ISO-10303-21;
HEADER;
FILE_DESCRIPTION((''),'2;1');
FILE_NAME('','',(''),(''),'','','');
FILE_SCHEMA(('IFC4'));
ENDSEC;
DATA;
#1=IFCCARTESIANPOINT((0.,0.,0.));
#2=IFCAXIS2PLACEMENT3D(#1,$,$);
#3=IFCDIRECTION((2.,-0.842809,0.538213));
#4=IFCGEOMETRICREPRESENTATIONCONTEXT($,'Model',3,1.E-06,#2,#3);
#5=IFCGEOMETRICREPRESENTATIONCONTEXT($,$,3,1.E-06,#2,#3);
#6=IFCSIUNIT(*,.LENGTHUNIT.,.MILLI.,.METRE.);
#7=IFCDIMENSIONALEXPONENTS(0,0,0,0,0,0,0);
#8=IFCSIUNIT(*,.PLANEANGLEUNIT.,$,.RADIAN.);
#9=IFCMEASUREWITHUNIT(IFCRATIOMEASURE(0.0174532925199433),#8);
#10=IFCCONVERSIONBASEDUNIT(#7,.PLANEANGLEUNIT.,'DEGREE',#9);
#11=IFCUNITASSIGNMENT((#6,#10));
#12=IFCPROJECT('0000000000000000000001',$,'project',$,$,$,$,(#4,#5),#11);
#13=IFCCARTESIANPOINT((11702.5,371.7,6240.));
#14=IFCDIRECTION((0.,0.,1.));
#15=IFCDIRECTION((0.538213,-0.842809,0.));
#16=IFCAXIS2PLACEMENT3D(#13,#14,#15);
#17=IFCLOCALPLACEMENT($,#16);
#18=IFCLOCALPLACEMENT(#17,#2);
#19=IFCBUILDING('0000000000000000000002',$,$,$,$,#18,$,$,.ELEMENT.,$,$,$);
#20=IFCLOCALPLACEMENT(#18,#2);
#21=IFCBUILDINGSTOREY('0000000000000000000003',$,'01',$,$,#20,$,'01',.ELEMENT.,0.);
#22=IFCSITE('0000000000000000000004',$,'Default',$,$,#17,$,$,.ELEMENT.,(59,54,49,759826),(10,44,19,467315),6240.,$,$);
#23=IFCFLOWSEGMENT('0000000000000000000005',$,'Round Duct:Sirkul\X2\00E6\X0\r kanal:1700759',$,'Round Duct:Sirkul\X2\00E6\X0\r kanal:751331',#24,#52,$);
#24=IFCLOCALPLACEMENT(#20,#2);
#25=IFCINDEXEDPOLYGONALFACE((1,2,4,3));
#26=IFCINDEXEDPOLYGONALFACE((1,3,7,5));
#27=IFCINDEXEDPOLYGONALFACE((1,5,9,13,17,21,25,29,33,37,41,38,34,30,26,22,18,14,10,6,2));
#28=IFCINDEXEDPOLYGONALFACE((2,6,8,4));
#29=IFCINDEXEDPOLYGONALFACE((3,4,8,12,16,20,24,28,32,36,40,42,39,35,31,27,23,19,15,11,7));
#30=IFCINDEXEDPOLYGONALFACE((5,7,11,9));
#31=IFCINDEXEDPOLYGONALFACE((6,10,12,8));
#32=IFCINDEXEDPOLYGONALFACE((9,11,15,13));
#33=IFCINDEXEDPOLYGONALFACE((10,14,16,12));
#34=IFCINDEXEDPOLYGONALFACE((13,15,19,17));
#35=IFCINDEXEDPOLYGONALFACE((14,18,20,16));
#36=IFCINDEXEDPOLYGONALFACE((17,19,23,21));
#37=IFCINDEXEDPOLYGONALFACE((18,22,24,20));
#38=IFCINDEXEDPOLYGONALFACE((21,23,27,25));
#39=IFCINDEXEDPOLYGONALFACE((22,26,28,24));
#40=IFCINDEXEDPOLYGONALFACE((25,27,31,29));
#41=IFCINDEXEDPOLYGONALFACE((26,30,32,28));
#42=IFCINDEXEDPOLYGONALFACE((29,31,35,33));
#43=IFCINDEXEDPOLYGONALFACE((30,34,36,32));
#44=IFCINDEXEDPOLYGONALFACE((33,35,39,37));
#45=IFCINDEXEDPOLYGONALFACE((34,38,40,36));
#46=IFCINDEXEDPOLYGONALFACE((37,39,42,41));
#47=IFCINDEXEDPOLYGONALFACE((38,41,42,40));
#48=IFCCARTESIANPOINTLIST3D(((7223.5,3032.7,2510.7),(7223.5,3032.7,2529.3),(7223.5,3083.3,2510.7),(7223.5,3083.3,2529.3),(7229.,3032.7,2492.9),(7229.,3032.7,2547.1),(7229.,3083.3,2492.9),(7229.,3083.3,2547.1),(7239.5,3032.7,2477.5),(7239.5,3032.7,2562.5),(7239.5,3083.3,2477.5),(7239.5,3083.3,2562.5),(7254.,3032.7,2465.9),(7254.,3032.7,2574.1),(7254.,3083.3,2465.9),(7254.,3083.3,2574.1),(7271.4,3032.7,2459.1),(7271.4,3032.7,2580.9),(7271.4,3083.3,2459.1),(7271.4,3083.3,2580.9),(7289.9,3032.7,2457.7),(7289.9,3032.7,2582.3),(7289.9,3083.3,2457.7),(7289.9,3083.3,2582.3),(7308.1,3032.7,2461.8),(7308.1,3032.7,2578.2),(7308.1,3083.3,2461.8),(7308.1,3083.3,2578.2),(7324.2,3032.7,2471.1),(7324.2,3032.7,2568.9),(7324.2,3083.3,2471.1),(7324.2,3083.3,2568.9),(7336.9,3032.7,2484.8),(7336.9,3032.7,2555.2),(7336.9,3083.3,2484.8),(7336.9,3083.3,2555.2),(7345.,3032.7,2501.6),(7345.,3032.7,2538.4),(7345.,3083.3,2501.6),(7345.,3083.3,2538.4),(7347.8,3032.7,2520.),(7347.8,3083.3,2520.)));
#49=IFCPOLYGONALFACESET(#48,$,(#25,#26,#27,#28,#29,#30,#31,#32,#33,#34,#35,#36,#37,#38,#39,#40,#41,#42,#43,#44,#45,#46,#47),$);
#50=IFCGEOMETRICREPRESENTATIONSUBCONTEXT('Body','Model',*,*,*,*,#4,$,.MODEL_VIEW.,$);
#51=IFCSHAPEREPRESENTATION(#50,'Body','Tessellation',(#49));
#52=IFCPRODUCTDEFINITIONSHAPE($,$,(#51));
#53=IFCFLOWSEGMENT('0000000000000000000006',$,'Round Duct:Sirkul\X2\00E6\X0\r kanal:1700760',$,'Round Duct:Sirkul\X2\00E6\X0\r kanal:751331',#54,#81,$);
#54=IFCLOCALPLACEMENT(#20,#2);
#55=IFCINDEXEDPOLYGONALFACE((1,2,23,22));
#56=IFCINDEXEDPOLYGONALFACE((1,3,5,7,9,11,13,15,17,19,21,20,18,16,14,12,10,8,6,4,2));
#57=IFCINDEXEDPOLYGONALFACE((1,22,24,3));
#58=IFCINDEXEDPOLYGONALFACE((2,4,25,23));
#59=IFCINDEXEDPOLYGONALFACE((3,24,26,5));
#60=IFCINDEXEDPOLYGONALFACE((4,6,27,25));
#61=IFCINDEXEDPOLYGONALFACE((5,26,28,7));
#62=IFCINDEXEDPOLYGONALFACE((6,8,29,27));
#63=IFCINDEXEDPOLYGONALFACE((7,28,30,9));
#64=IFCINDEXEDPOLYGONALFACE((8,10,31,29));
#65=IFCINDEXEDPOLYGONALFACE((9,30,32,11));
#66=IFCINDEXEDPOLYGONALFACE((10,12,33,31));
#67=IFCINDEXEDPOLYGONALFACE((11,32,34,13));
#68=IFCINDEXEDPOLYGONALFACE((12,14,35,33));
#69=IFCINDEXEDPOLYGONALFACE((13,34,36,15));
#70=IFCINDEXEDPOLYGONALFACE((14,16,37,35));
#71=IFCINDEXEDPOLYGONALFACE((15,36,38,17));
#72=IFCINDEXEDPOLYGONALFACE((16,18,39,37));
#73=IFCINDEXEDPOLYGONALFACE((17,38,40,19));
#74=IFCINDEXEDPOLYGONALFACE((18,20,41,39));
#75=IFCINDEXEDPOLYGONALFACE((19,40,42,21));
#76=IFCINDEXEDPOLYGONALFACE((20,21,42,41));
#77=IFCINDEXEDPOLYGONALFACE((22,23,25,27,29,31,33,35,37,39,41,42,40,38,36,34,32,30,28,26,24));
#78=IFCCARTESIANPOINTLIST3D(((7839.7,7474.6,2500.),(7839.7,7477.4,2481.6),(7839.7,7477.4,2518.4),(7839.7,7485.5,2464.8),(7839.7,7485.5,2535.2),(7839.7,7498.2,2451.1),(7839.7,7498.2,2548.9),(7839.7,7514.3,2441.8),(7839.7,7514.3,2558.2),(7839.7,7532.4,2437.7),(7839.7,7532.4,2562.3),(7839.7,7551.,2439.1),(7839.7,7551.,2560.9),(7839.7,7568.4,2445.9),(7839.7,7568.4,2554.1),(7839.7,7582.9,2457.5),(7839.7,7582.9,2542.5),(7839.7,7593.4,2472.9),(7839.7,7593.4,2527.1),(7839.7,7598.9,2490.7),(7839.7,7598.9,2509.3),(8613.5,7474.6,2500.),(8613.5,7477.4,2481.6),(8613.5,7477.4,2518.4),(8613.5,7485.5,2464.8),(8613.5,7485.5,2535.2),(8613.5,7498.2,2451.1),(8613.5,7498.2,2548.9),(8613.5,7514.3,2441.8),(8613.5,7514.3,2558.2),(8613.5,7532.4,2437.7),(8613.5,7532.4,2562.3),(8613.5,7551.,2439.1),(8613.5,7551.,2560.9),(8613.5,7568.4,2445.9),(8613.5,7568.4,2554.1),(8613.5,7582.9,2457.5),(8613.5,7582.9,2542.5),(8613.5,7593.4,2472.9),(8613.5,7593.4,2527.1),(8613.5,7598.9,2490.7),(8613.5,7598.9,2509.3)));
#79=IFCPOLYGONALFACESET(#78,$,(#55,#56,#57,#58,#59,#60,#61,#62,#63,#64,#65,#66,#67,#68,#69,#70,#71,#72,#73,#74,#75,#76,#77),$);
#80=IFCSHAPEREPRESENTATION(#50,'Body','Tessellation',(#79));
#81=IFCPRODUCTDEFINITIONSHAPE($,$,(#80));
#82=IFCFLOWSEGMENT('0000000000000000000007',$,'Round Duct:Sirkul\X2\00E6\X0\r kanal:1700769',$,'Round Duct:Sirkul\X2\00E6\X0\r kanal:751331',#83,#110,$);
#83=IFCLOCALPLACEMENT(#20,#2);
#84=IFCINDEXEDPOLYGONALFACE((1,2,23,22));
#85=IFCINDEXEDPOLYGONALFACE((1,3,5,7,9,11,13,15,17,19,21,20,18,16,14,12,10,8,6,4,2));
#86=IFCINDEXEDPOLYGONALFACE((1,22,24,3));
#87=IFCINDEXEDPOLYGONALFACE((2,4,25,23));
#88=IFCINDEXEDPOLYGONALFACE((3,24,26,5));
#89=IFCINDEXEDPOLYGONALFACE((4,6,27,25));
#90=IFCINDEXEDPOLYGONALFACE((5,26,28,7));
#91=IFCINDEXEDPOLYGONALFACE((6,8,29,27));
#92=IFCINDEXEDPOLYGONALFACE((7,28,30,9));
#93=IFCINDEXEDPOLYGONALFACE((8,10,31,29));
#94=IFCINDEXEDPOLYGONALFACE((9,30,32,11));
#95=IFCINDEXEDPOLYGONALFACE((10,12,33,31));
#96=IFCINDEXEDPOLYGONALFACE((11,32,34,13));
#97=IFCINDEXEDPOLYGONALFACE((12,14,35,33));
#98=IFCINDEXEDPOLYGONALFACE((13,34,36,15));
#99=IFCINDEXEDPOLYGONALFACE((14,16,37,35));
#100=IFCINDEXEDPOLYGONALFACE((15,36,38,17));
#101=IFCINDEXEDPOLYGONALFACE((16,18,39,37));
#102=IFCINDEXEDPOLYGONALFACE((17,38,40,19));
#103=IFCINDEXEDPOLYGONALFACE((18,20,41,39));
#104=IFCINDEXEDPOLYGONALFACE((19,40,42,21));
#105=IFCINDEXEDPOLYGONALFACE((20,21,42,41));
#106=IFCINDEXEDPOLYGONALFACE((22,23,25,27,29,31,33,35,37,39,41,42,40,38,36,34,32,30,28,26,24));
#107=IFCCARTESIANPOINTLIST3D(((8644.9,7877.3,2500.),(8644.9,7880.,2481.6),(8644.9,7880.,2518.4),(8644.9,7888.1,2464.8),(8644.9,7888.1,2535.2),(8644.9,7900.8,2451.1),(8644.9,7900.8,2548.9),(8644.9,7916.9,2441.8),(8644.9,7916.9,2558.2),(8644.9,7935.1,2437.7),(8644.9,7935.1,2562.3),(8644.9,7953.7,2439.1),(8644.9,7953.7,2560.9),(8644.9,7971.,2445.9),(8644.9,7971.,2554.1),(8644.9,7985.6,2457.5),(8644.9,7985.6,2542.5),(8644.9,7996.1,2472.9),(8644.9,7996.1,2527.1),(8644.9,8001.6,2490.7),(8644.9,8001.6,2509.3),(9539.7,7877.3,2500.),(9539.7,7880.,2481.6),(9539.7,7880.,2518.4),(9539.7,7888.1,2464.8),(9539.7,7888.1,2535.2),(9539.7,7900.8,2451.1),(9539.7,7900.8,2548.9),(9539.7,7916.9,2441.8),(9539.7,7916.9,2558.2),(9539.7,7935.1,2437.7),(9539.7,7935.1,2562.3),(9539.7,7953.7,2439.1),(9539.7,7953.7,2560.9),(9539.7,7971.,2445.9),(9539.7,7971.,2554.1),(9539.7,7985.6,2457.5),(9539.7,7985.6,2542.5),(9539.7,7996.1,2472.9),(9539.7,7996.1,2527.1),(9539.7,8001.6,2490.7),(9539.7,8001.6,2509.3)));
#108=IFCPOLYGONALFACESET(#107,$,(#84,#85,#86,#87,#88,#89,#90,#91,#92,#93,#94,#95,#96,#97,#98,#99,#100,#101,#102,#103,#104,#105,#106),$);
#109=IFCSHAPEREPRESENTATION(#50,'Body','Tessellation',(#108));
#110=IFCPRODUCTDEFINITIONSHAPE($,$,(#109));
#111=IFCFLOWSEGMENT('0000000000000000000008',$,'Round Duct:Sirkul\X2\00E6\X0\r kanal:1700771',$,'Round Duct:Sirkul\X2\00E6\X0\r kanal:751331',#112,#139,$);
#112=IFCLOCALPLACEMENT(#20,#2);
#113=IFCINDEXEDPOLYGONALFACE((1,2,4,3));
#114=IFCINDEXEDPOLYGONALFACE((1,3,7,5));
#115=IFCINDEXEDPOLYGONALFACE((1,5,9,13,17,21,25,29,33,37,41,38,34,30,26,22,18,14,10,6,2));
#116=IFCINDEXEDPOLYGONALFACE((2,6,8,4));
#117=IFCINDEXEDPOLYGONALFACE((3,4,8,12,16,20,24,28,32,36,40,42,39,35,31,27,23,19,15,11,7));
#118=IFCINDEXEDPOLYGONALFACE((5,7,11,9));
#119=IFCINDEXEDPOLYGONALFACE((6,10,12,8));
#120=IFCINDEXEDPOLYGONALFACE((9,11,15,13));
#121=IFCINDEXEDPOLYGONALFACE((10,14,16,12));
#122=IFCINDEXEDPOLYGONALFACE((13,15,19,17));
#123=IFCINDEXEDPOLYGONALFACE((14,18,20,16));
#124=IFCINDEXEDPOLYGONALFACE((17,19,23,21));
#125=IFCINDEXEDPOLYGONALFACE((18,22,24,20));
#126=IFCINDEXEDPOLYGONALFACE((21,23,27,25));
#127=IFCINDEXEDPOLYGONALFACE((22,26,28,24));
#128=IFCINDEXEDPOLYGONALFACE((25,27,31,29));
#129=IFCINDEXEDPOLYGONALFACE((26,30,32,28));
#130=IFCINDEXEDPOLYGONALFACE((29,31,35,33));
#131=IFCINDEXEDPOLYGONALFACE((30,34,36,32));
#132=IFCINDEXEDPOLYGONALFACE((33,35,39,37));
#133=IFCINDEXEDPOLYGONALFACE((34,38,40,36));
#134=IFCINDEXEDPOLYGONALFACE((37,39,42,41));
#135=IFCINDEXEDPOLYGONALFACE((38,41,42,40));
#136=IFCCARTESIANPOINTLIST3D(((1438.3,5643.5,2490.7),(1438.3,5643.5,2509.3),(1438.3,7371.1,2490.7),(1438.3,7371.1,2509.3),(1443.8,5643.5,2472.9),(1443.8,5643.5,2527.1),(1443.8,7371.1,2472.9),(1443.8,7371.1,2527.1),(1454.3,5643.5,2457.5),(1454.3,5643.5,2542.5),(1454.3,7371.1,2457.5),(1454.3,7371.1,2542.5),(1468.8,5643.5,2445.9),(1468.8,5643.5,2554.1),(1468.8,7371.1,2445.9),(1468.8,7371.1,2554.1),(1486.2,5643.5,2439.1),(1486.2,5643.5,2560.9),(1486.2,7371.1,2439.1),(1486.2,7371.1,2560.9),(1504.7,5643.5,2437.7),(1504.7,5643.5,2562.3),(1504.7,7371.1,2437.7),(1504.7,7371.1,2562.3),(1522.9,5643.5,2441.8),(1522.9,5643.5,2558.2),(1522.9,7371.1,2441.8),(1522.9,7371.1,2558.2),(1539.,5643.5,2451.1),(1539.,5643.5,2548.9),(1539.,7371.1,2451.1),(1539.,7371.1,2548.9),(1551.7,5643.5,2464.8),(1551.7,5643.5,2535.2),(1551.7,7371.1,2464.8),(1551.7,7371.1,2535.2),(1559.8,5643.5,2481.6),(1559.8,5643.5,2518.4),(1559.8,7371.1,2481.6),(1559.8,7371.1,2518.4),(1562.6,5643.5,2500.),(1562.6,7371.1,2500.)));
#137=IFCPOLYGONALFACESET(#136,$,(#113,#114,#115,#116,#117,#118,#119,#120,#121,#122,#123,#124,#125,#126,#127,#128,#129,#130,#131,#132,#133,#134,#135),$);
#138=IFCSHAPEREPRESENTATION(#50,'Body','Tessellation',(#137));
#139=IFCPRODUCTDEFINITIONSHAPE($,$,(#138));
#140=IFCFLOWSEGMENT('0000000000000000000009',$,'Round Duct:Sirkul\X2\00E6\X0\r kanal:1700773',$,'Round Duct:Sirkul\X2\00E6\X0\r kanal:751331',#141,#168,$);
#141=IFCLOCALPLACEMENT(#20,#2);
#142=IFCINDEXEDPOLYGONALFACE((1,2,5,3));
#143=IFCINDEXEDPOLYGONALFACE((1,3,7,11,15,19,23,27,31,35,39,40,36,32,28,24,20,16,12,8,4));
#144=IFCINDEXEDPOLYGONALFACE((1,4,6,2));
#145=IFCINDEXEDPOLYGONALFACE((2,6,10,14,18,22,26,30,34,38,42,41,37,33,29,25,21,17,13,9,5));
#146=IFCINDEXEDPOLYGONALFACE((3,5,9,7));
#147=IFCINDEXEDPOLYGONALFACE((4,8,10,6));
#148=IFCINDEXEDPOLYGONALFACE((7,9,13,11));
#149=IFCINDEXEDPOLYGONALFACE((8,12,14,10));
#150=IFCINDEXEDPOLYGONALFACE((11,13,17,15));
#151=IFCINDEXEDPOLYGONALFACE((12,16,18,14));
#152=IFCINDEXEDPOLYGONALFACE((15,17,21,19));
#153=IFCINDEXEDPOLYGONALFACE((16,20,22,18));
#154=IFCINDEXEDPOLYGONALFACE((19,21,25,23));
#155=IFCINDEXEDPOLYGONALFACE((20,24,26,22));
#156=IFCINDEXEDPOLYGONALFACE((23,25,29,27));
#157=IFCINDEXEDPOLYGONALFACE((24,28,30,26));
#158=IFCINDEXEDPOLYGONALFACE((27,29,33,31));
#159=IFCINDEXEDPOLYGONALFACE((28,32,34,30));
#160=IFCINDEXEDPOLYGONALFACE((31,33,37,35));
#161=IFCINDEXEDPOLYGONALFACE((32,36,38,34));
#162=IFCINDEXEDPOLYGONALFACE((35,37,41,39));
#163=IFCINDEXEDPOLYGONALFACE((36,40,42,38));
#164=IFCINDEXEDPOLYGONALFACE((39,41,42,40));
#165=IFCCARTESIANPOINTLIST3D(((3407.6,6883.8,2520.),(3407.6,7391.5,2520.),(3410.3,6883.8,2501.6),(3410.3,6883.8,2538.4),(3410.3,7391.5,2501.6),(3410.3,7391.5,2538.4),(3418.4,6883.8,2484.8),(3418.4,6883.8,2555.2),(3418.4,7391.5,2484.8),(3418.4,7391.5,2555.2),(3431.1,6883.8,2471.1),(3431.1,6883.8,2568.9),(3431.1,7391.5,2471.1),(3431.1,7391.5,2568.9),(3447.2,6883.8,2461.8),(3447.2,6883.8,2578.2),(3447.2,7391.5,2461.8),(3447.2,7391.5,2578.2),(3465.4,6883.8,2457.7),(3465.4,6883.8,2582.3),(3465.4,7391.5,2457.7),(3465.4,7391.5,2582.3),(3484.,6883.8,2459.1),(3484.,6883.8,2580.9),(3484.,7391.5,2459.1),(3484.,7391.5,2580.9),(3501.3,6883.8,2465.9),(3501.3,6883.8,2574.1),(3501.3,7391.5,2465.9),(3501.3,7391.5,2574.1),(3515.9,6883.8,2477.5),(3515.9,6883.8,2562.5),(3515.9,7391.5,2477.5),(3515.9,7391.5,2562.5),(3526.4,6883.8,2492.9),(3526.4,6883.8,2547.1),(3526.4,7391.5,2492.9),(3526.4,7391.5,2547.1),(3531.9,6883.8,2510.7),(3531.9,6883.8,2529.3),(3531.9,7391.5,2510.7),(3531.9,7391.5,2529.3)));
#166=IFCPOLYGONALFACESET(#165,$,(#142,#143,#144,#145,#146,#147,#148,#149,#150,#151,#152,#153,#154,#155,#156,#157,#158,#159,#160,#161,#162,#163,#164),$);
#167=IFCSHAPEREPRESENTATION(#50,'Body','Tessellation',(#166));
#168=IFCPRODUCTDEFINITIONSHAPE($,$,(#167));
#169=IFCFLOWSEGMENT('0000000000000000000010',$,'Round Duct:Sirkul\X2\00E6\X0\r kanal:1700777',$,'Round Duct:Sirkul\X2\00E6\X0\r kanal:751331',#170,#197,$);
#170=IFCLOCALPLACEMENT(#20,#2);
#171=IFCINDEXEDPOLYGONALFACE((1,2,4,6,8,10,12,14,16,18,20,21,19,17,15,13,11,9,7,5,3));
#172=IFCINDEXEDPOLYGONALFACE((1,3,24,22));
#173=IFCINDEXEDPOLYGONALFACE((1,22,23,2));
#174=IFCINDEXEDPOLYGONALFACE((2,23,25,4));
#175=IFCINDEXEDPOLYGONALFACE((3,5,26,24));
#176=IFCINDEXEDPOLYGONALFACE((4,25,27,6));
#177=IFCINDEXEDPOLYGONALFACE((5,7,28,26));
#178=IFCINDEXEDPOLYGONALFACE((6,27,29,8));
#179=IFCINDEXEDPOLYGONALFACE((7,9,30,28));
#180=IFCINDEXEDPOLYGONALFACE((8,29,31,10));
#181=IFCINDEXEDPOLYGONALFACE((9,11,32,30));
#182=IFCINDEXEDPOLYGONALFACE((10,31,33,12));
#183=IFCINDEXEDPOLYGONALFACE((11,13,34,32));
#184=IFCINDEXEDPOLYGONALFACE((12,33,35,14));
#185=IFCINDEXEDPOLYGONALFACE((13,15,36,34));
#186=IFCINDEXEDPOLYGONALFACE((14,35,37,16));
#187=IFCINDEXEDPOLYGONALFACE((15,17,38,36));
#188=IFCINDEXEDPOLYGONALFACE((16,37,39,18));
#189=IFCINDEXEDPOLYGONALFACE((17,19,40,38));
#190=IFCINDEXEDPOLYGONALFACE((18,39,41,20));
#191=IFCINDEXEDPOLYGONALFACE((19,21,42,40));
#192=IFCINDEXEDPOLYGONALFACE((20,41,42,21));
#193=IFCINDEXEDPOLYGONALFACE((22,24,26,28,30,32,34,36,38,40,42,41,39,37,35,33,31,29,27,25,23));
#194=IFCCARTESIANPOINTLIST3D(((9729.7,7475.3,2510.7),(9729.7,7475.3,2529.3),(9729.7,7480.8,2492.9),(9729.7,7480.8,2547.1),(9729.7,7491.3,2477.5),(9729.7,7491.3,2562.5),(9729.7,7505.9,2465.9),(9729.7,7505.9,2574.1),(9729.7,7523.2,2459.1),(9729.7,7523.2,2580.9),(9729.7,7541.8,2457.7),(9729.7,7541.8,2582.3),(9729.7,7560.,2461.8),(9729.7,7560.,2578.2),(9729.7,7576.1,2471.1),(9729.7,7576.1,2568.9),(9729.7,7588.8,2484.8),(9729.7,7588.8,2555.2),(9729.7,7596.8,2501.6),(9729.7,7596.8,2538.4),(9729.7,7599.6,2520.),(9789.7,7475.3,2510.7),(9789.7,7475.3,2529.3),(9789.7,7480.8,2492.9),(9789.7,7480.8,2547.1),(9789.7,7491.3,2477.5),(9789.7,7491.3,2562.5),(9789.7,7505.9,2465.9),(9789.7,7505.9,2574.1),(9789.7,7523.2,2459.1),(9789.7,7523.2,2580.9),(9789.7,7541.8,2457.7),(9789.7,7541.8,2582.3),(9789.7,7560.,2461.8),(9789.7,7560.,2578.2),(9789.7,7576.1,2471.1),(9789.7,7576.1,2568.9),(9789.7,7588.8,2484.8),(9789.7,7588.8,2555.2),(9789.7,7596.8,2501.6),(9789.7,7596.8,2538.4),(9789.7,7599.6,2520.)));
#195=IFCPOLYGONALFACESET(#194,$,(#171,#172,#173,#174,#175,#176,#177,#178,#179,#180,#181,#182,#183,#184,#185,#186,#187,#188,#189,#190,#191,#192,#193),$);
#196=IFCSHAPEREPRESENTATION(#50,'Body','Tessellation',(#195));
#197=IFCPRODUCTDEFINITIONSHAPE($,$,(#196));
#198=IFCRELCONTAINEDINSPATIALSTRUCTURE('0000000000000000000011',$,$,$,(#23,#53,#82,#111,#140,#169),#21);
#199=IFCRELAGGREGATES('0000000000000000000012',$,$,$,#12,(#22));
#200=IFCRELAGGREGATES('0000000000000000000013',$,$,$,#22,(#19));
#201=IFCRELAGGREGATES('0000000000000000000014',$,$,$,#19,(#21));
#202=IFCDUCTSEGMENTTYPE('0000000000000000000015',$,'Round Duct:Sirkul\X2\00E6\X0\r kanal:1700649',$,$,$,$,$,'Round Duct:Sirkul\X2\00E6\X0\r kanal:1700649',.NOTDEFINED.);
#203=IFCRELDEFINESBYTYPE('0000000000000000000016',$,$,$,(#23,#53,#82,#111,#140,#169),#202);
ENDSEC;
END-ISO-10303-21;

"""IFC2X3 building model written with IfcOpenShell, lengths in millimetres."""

from ifc_helpers import new_model, entity, si_unit, converted_unit, direction, frame, frame_2d, origin, origin_2d_with_axis, place, context, subcontext, project, spatial, circle, extrude, type_object, element, save


model = new_model("IFC2X3")

# Units and contexts
model_context = context("Model", 3, precision=1e-06, world=origin(), true_north=direction((2.0, -0.842809, 0.538213)))
context_of_model = context(None, 3, precision=1e-06, world=origin(), true_north=direction((2.0, -0.842809, 0.538213)))
body_context = subcontext(model_context, "Body", "Model", "MODEL_VIEW")
ifc_project = project(units=[si_unit("LENGTHUNIT", "METRE", prefix="MILLI"), converted_unit("PLANEANGLEUNIT", "DEGREE", entity("IfcRatioMeasure", 0.0174532925199433), si_unit("PLANEANGLEUNIT", "RADIAN"), dimensions=[0, 0, 0, 0, 0, 0, 0])], contexts=[model_context, context_of_model])

# Site, building, storey
site_placement = place(None, frame((11702.5, 371.7, 6240.0), z_axis=(0.0, 0.0, 1.0), x_axis=(0.538213, -0.842809, 0.0)))
site = spatial("IfcSite", under=ifc_project, at=site_placement, Name="Default", CompositionType="ELEMENT", RefLatitude=(59, 54, 49, 759826), RefLongitude=(10, 44, 19, 467315), RefElevation=6240.0)
building_placement = place(site_placement, origin())
building = spatial("IfcBuilding", under=site, at=building_placement, CompositionType="ELEMENT")
storey_placement = place(building_placement, origin())
storey = spatial("IfcBuildingStorey", under=building, at=storey_placement, Name="01", LongName="01", CompositionType="ELEMENT", Elevation=0.0)

# Flow segments
duct_segment_type = type_object("IfcDuctSegmentType", Name="Round Duct:Sirkulær kanal:1700649", ElementType="Round Duct:Sirkulær kanal:1700649", PredefinedType="NOTDEFINED")
flow_segment_1_placement = place(storey_placement, origin())
element("IfcFlowSegment", 1, at=flow_segment_1_placement, inside=storey, type_object=duct_segment_type, Name="Round Duct:Sirkulær kanal:1700759", ObjectType="Round Duct:Sirkulær kanal:751331", context=body_context, shape_type="SweptSolid", body=[
    extrude(circle(Radius=62.5, at=origin_2d_with_axis()), frame((7285.3, 3032.7, 2520.0), z_axis=(0.0, 1.0, 0.0), x_axis=(1.0, 0.0, 0.0)), (0.0, 0.0, 1.0), 50.7),
])
flow_segment_2_placement = place(storey_placement, origin())
element("IfcFlowSegment", 2, at=flow_segment_2_placement, inside=storey, type_object=duct_segment_type, Name="Round Duct:Sirkulær kanal:1700760", ObjectType="Round Duct:Sirkulær kanal:751331", context=body_context, shape_type="SweptSolid", body=[
    extrude(circle(Radius=62.5, at=origin_2d_with_axis()), frame((7839.7, 7537.1, 2500.0), z_axis=(1.0, 0.0, 0.0), x_axis=(0.0, -1.0, 0.0)), (0.0, 0.0, 1.0), 773.8),
])
flow_segment_3_placement = place(storey_placement, origin())
element("IfcFlowSegment", 3, at=flow_segment_3_placement, inside=storey, type_object=duct_segment_type, Name="Round Duct:Sirkulær kanal:1700769", ObjectType="Round Duct:Sirkulær kanal:751331", context=body_context, shape_type="SweptSolid", body=[
    extrude(circle(Radius=62.5, at=origin_2d_with_axis()), frame((8644.9, 7939.8, 2500.0), z_axis=(1.0, 0.0, 0.0), x_axis=(0.0, -1.0, 0.0)), (0.0, 0.0, 1.0), 894.8),
])
flow_segment_4_placement = place(storey_placement, origin())
element("IfcFlowSegment", 4, at=flow_segment_4_placement, inside=storey, type_object=duct_segment_type, Name="Round Duct:Sirkulær kanal:1700771", ObjectType="Round Duct:Sirkulær kanal:751331", context=body_context, shape_type="SweptSolid", body=[
    extrude(circle(Radius=62.5, at=origin_2d_with_axis()), frame((1500.1, 5643.5, 2500.0), z_axis=(0.0, 1.0, 0.0), x_axis=(1.0, 0.0, 0.0)), (0.0, 0.0, 1.0), 1727.6),
])
flow_segment_5_placement = place(storey_placement, origin())
element("IfcFlowSegment", 5, at=flow_segment_5_placement, inside=storey, type_object=duct_segment_type, Name="Round Duct:Sirkulær kanal:1700773", ObjectType="Round Duct:Sirkulær kanal:751331", context=body_context, shape_type="SweptSolid", body=[
    extrude(circle(Radius=62.5, at=origin_2d_with_axis()), frame((3470.1, 6883.8, 2520.0), z_axis=(0.0, 1.0, 0.0), x_axis=(-1.0, 0.0, 0.0)), (0.0, 0.0, 1.0), 507.7),
])
flow_segment_6_placement = place(storey_placement, origin())
element("IfcFlowSegment", 6, at=flow_segment_6_placement, inside=storey, type_object=duct_segment_type, Name="Round Duct:Sirkulær kanal:1700777", ObjectType="Round Duct:Sirkulær kanal:751331", context=body_context, shape_type="SweptSolid", body=[
    extrude(circle(Radius=62.5, at=frame_2d((0.0, 0.0), x_axis=(1.0, 0.0))), frame((9729.7, 7537.1, 2520.0), z_axis=(1.0, 0.0, 0.0), x_axis=(0.0, 1.0, 0.0)), (0.0, 0.0, 1.0), 60.0),
])

save(model, "model.ifc")
